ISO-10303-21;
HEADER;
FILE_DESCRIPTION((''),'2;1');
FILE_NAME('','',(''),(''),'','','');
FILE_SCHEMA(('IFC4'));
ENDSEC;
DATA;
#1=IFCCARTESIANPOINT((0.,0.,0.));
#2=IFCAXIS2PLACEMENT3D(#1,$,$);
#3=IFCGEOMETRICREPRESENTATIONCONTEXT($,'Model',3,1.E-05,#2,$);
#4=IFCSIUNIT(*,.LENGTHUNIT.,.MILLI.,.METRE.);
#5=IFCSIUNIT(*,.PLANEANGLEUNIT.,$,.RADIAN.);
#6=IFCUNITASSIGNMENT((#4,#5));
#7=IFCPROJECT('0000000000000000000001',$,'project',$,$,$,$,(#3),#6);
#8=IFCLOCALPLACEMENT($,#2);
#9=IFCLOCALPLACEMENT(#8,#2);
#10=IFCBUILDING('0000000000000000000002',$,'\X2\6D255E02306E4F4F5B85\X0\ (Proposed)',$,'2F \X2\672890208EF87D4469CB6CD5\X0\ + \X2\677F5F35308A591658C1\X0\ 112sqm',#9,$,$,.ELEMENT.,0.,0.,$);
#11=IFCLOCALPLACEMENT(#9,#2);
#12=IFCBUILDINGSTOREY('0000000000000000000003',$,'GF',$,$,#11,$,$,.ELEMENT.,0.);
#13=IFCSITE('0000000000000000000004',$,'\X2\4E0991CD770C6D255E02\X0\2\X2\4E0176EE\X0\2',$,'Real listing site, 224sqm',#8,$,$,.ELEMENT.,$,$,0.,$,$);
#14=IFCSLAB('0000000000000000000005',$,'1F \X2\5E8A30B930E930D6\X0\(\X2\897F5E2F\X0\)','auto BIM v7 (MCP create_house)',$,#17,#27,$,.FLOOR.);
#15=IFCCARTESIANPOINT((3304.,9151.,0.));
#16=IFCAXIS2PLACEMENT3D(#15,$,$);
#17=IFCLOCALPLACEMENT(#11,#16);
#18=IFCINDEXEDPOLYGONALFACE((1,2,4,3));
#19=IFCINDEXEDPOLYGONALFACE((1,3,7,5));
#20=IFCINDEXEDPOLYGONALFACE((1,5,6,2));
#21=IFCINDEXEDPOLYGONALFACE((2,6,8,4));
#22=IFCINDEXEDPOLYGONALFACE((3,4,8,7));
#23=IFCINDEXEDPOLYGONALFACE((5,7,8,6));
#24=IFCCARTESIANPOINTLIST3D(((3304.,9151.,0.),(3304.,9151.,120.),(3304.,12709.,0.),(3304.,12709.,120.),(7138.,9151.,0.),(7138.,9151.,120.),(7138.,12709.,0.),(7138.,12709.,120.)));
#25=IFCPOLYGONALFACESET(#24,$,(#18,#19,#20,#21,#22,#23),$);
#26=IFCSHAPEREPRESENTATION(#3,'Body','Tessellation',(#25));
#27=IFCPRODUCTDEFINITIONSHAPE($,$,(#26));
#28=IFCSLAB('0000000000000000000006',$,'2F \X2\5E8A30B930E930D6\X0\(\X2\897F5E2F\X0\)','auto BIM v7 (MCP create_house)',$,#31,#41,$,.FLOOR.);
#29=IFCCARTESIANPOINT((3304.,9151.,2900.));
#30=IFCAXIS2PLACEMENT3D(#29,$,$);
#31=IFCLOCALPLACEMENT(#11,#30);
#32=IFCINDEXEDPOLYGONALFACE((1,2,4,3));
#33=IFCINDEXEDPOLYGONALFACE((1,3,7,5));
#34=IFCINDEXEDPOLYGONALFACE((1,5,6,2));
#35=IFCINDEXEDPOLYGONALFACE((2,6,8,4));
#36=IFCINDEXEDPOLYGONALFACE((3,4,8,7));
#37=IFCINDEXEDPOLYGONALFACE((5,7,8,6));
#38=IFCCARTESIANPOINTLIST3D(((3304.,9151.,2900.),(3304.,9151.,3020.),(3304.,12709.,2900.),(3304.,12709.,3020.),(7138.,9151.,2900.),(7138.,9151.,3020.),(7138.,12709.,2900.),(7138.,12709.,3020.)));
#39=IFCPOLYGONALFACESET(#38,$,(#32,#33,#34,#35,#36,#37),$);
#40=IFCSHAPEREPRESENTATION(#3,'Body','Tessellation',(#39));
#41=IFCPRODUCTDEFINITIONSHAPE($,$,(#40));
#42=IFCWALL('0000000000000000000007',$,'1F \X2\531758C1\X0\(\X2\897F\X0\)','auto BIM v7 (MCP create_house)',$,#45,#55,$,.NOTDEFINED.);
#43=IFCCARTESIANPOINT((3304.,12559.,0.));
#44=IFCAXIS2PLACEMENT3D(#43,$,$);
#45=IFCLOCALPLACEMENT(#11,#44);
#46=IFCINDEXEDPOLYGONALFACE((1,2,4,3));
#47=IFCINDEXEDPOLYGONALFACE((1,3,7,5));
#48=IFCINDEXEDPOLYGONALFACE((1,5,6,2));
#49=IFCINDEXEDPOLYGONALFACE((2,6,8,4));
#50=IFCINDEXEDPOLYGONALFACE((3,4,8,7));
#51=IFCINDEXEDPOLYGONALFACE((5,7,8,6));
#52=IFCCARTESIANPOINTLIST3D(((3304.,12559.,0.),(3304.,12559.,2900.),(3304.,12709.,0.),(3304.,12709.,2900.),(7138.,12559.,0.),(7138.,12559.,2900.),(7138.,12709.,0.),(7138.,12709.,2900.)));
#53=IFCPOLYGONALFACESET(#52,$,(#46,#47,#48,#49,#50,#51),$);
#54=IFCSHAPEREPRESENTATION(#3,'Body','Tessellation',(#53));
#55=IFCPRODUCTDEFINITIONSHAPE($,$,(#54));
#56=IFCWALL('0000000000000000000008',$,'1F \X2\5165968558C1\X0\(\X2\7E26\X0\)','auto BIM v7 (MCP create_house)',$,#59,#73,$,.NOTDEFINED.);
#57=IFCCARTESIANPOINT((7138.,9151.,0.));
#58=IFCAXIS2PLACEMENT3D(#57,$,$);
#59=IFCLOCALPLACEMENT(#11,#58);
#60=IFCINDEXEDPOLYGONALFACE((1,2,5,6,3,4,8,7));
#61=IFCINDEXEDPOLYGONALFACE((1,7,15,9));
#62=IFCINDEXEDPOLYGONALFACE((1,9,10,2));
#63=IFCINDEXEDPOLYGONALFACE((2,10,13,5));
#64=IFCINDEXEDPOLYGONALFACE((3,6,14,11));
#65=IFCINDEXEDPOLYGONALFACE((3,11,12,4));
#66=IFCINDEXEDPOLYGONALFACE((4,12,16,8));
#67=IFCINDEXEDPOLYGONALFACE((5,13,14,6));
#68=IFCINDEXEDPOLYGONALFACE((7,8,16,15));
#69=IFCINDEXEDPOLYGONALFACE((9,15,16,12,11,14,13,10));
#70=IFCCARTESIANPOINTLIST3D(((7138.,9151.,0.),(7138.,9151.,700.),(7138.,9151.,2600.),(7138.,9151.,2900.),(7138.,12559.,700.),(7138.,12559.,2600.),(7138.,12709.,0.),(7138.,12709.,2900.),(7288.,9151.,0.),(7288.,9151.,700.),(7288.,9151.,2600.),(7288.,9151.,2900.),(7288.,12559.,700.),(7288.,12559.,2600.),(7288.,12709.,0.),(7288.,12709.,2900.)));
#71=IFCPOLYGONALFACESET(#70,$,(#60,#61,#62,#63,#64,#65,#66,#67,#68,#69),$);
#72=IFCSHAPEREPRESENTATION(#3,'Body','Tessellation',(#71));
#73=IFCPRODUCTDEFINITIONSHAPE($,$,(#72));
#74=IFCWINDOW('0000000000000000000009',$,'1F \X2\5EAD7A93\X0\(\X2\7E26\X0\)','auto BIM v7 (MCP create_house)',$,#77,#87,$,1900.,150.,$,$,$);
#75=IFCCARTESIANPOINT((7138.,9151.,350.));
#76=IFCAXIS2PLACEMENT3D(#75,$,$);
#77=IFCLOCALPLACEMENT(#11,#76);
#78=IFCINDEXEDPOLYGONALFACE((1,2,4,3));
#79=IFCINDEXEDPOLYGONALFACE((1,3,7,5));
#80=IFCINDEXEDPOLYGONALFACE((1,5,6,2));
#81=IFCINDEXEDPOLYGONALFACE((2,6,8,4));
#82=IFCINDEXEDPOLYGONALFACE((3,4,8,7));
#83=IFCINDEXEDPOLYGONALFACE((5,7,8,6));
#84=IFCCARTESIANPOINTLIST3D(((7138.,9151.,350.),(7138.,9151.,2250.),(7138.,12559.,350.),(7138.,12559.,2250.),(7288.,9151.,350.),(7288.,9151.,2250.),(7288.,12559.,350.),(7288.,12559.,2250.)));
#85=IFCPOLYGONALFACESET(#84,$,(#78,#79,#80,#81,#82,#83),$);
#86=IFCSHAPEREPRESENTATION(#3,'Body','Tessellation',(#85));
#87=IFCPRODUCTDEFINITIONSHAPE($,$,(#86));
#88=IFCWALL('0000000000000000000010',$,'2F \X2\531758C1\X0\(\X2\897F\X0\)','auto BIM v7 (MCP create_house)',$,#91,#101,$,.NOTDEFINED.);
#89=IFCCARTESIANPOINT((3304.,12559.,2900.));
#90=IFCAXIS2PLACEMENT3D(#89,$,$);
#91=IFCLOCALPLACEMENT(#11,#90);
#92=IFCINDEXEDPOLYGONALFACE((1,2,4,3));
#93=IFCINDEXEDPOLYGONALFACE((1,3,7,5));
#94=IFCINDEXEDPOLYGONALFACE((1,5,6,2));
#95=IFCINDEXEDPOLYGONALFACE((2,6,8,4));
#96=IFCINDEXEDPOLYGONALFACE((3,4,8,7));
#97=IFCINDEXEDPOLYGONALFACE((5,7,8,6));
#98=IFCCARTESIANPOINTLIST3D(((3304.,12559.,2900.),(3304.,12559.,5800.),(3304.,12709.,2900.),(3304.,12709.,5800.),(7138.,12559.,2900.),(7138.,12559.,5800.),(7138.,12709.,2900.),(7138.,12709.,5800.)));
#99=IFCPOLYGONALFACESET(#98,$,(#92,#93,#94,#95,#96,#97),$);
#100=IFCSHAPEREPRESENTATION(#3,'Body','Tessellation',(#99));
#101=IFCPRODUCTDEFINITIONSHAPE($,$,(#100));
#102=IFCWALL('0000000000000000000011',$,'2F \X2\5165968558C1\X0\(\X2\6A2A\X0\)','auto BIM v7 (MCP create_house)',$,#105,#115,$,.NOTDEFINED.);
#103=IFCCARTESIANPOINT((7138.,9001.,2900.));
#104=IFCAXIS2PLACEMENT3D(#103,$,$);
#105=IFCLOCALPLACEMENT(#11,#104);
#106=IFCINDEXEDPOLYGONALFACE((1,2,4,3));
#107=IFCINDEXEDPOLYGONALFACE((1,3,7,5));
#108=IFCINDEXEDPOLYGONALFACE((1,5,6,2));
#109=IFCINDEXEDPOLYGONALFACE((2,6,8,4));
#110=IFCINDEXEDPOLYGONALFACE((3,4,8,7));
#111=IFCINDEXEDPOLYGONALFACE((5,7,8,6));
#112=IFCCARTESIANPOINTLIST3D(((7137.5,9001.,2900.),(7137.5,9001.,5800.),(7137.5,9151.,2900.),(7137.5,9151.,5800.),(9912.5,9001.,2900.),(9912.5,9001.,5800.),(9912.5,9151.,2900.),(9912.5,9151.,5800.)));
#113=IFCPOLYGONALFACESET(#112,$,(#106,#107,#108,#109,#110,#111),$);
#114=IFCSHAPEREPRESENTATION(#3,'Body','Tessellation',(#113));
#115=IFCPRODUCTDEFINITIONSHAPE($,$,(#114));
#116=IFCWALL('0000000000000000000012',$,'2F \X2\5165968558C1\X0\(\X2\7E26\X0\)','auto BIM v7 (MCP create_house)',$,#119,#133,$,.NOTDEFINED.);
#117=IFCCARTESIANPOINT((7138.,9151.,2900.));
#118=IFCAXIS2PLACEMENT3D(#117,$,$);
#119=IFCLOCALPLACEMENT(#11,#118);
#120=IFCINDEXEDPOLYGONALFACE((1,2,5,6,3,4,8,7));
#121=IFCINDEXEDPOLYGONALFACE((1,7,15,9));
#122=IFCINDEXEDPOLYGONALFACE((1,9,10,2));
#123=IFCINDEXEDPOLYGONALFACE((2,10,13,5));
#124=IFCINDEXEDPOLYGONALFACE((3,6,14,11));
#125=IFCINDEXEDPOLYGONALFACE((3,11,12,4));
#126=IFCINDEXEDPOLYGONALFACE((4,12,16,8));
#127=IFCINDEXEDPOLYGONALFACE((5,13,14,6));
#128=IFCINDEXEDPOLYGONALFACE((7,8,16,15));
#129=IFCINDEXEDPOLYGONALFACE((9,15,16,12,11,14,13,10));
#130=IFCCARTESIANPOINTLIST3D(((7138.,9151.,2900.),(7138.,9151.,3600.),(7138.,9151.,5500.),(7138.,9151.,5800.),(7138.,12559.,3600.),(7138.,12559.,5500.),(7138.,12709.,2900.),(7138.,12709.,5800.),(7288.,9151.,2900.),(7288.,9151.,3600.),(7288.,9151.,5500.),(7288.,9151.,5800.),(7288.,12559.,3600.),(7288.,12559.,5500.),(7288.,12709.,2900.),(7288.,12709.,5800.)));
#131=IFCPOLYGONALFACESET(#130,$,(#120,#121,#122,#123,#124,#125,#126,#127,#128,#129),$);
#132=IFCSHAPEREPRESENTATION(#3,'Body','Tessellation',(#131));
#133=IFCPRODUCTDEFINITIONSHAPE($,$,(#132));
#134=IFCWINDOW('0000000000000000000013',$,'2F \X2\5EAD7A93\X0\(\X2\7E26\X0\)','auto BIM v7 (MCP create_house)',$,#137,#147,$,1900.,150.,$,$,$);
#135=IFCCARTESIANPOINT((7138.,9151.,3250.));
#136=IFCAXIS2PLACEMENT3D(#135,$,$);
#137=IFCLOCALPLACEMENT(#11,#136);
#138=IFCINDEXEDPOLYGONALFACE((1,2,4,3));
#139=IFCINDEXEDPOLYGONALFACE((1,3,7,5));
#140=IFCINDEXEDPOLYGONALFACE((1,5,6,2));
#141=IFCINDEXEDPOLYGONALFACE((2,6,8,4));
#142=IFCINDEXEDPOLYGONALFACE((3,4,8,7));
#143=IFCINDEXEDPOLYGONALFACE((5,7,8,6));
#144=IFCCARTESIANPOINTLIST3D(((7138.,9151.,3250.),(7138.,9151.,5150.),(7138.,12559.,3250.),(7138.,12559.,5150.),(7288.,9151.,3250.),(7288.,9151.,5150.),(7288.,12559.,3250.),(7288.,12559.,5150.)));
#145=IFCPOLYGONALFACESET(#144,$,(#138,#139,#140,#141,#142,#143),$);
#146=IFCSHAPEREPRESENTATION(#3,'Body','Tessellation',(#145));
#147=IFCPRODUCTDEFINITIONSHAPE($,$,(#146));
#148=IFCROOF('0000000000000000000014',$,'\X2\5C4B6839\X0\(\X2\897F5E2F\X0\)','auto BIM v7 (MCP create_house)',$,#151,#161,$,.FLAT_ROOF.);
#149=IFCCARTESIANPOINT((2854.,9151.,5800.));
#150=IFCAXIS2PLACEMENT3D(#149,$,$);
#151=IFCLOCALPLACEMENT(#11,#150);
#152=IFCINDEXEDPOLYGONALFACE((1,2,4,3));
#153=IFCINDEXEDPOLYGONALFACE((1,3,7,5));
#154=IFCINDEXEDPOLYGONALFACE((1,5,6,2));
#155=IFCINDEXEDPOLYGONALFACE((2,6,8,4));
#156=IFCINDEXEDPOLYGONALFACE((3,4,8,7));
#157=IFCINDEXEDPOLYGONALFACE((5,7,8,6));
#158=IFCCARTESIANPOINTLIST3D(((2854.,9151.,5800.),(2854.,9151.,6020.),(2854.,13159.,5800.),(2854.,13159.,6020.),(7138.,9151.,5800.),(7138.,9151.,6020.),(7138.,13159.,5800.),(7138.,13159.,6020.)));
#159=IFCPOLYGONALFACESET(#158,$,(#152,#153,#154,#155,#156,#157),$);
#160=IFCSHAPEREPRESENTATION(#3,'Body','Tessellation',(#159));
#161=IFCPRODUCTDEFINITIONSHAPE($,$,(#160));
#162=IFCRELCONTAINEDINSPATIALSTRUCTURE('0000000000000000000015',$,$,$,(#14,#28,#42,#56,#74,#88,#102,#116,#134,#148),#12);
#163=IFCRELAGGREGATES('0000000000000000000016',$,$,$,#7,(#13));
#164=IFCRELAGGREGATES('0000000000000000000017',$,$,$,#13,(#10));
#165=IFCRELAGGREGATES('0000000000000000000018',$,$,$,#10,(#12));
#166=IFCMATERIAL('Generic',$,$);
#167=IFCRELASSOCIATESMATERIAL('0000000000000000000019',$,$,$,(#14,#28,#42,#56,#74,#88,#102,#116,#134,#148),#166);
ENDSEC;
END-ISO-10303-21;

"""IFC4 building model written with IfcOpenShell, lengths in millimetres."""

from ifc_helpers import new_model, si_unit, frame, frame_2d, origin, place, context, project, spatial, rectangle, extrude, material, element, fill, save


model = new_model("IFC4")

# Units and contexts
model_context = context("Model", 3, precision=1e-05, world=origin())
ifc_project = project(units=[si_unit("LENGTHUNIT", "METRE", prefix="MILLI"), si_unit("PLANEANGLEUNIT", "RADIAN")], contexts=[model_context])

# Site, building, storey
site_placement = place(None, origin())
site = spatial("IfcSite", under=ifc_project, at=site_placement, Name="三重県津市2丁目2", ObjectType="Real listing site, 224sqm", CompositionType="ELEMENT", RefElevation=0.0)
building_placement = place(site_placement, origin())
building = spatial("IfcBuilding", under=site, at=building_placement, Name="津市の住宅 (Proposed)", ObjectType="2F 木造軸組構法 + 板張り外壁 112sqm", CompositionType="ELEMENT", ElevationOfRefHeight=0.0, ElevationOfTerrain=0.0)
storey_placement = place(building_placement, origin())
storey = spatial("IfcBuildingStorey", under=building, at=storey_placement, Name="GF", CompositionType="ELEMENT", Elevation=0.0)

# Slabs
ifc_material = material(Name="Generic")
slab_1_placement = place(storey_placement, frame((3304.0, 9151.0, 0.0)))
element("IfcSlab", 1, at=slab_1_placement, inside=storey, material=ifc_material, Name="1F 床スラブ(西帯)", Description="auto BIM v7 (MCP create_house)", PredefinedType="FLOOR", context=model_context, shape_type="SweptSolid", body=[
    extrude(rectangle(XDim=3834.0, YDim=3558.0, at=frame_2d((1917.0, 1779.0))), frame((3304.0, 9151.0, 0.0)), (0.0, 0.0, 1.0), 120.0),
])
slab_2_placement = place(storey_placement, frame((3304.0, 9151.0, 2900.0)))
element("IfcSlab", 2, at=slab_2_placement, inside=storey, material=ifc_material, Name="2F 床スラブ(西帯)", Description="auto BIM v7 (MCP create_house)", PredefinedType="FLOOR", context=model_context, shape_type="SweptSolid", body=[
    extrude(rectangle(XDim=3834.0, YDim=3558.0, at=frame_2d((1917.0, 1779.0))), frame((3304.0, 9151.0, 2900.0)), (0.0, 0.0, 1.0), 120.0),
])

# Wall
wall_1_placement = place(storey_placement, frame((3304.0, 12559.0, 0.0)))
element("IfcWall", 3, at=wall_1_placement, inside=storey, material=ifc_material, Name="1F 北壁(西)", Description="auto BIM v7 (MCP create_house)", PredefinedType="NOTDEFINED", context=model_context, shape_type="SweptSolid", body=[
    extrude(rectangle(XDim=3834.0, YDim=150.0, at=frame_2d((1917.0, 75.0))), frame((3304.0, 12559.0, 0.0)), (0.0, 0.0, 1.0), 2900.0),
])

# Wall, opening, window
wall_2_placement = place(storey_placement, frame((7138.0, 9151.0, 0.0)))
wall_2 = element("IfcWall", 4, at=wall_2_placement, inside=storey, material=ifc_material, Name="1F 入隅壁(縦)", Description="auto BIM v7 (MCP create_house)", PredefinedType="NOTDEFINED", context=model_context, shape_type="SweptSolid", body=[
    extrude(rectangle(XDim=150.0, YDim=3558.0, at=frame_2d((75.0, 1779.0))), frame((7138.0, 9151.0, 0.0)), (0.0, 0.0, 1.0), 2900.0),
])
opening_1_placement = place(storey_placement, frame((7138.0, 9151.0, 350.0)))
opening_1 = element("IfcOpeningElement", 5, at=opening_1_placement, cuts=wall_2, PredefinedType="NOTDEFINED", context=model_context, shape_type="SweptSolid", body=[
    extrude(rectangle(XDim=150.0, YDim=3408.0, at=frame_2d((75.0, 1704.0))), frame((7138.0, 9151.0, 350.0)), (0.0, 0.0, 1.0), 1900.0),
])
window_1_placement = place(storey_placement, frame((7138.0, 9151.0, 350.0)))
window_1 = element("IfcWindow", 6, at=window_1_placement, inside=storey, material=ifc_material, Name="1F 庭窓(縦)", Description="auto BIM v7 (MCP create_house)", OverallHeight=1900.0, OverallWidth=150.0, context=model_context, shape_type="SweptSolid", body=[
    extrude(rectangle(XDim=150.0, YDim=3408.0, at=frame_2d((75.0, 1704.0))), frame((7138.0, 9151.0, 350.0)), (0.0, 0.0, 1.0), 1900.0),
])
fill(opening_1, window_1)

# Walls
wall_3_placement = place(storey_placement, frame((3304.0, 12559.0, 2900.0)))
element("IfcWall", 7, at=wall_3_placement, inside=storey, material=ifc_material, Name="2F 北壁(西)", Description="auto BIM v7 (MCP create_house)", PredefinedType="NOTDEFINED", context=model_context, shape_type="SweptSolid", body=[
    extrude(rectangle(XDim=3834.0, YDim=150.0, at=frame_2d((1917.0, 75.0))), frame((3304.0, 12559.0, 2900.0)), (0.0, 0.0, 1.0), 2900.0),
])
wall_4_placement = place(storey_placement, frame((7138.0, 9001.0, 2900.0)))
element("IfcWall", 8, at=wall_4_placement, inside=storey, material=ifc_material, Name="2F 入隅壁(横)", Description="auto BIM v7 (MCP create_house)", PredefinedType="NOTDEFINED", context=model_context, shape_type="SweptSolid", body=[
    extrude(rectangle(XDim=2775.0, YDim=150.0, at=frame_2d((1387.0, 75.0))), frame((7138.0, 9001.0, 2900.0)), (0.0, 0.0, 1.0), 2900.0),
])

# Wall, opening, window
wall_5_placement = place(storey_placement, frame((7138.0, 9151.0, 2900.0)))
wall_5 = element("IfcWall", 9, at=wall_5_placement, inside=storey, material=ifc_material, Name="2F 入隅壁(縦)", Description="auto BIM v7 (MCP create_house)", PredefinedType="NOTDEFINED", context=model_context, shape_type="SweptSolid", body=[
    extrude(rectangle(XDim=150.0, YDim=3558.0, at=frame_2d((75.0, 1779.0))), frame((7138.0, 9151.0, 2900.0)), (0.0, 0.0, 1.0), 2900.0),
])
opening_2_placement = place(storey_placement, frame((7138.0, 9151.0, 3250.0)))
opening_2 = element("IfcOpeningElement", 10, at=opening_2_placement, cuts=wall_5, PredefinedType="NOTDEFINED", context=model_context, shape_type="SweptSolid", body=[
    extrude(rectangle(XDim=150.0, YDim=3408.0, at=frame_2d((75.0, 1704.0))), frame((7138.0, 9151.0, 3250.0)), (0.0, 0.0, 1.0), 1900.0),
])
window_2_placement = place(storey_placement, frame((7138.0, 9151.0, 3250.0)))
window_2 = element("IfcWindow", 11, at=window_2_placement, inside=storey, material=ifc_material, Name="2F 庭窓(縦)", Description="auto BIM v7 (MCP create_house)", OverallHeight=1900.0, OverallWidth=150.0, context=model_context, shape_type="SweptSolid", body=[
    extrude(rectangle(XDim=150.0, YDim=3408.0, at=frame_2d((75.0, 1704.0))), frame((7138.0, 9151.0, 3250.0)), (0.0, 0.0, 1.0), 1900.0),
])
fill(opening_2, window_2)

# Roof
for number, where, name in (
    (12, (2854.0, 9151.0, 5800.0), "屋根(西帯)"),
):
    element("IfcRoof", number, at=place(storey_placement, frame(where)), inside=storey, material=ifc_material, Name=name, Description="auto BIM v7 (MCP create_house)", PredefinedType="FLAT_ROOF", context=model_context, shape_type="SweptSolid", body=[
        extrude(rectangle(XDim=4284.0, YDim=4008.0, at=frame_2d((2142.0, 2004.0))), frame((2854.0, 9151.0, 5800.0)), (0.0, 0.0, 1.0), 220.0),
    ])

save(model, "model.ifc")
